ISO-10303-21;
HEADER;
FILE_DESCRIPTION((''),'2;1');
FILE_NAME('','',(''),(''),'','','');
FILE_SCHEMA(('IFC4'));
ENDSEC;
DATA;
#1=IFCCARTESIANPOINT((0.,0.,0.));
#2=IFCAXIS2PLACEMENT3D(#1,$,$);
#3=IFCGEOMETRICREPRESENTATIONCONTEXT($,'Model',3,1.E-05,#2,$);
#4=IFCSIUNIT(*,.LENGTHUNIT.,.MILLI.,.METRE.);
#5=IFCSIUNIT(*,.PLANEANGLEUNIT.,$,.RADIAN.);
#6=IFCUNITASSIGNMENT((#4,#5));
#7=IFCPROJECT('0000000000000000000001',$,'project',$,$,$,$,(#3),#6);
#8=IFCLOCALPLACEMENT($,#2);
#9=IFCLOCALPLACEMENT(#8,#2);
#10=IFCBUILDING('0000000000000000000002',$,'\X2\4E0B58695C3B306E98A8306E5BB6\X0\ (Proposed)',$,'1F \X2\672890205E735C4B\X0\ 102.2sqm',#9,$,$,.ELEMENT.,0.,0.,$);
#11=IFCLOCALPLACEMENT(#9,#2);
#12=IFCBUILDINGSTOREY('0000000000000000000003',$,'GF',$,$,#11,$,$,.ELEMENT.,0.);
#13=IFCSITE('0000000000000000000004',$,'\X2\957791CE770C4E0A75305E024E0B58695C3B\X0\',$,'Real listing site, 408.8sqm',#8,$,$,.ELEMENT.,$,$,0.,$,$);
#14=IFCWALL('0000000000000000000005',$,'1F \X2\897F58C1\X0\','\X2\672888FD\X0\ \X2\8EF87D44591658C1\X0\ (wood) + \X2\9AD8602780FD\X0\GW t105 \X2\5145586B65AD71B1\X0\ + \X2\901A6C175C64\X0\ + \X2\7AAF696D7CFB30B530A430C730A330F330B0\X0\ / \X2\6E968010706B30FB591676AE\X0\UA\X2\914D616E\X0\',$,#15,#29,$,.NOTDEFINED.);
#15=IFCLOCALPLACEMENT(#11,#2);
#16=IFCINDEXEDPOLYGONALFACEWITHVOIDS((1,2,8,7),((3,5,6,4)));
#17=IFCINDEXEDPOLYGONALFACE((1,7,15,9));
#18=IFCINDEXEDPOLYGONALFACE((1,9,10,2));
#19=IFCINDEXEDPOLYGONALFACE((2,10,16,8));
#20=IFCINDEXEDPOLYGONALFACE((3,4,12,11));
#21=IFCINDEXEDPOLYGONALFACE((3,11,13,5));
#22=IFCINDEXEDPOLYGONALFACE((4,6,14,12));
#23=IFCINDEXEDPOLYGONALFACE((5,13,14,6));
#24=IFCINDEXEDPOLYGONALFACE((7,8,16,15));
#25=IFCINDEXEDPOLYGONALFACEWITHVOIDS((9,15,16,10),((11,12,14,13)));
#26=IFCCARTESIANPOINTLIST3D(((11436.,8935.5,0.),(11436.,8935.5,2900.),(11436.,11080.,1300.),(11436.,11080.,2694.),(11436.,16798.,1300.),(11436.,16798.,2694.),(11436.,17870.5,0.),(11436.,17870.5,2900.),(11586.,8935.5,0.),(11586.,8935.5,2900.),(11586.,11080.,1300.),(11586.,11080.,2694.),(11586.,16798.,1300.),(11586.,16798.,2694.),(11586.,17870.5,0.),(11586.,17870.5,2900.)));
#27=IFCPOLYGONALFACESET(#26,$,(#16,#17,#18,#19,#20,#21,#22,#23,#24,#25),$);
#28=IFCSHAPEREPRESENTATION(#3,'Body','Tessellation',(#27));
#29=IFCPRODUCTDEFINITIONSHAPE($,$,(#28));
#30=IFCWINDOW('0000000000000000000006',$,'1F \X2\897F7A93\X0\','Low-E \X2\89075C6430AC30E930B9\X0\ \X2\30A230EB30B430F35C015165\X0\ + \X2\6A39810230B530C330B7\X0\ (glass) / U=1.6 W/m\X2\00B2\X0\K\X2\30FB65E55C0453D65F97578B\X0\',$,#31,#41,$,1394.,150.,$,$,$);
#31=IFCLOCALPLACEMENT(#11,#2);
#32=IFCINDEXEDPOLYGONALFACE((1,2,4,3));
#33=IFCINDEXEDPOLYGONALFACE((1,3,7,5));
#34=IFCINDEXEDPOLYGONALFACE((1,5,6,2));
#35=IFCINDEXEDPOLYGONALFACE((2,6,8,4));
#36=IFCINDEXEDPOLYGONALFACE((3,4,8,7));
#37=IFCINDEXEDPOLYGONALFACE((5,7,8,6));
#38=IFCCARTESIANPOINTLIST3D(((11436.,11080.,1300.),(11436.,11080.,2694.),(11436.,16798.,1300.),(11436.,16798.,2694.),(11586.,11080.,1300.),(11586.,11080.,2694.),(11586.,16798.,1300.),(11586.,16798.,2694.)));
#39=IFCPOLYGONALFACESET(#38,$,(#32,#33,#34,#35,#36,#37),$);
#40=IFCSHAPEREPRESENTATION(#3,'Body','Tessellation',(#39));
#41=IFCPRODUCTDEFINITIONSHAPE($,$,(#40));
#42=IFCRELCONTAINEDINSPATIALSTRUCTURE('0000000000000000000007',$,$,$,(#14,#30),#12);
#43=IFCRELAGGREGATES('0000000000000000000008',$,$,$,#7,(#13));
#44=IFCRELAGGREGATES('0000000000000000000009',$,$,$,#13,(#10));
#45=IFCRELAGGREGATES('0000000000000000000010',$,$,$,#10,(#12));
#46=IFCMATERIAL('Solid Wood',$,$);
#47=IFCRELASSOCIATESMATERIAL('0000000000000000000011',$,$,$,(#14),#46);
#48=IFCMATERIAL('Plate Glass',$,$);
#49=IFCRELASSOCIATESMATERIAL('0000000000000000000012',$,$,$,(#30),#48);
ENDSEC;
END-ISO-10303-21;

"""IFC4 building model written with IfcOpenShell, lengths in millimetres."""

from ifc_helpers import new_model, si_unit, frame, frame_2d, origin, place, context, project, spatial, rectangle, extrude, material, element, fill, save


model = new_model("IFC4")

# Units and contexts
model_context = context("Model", 3, precision=1e-05, world=origin())
ifc_project = project(units=[si_unit("LENGTHUNIT", "METRE", prefix="MILLI"), si_unit("PLANEANGLEUNIT", "RADIAN")], contexts=[model_context])

# Site, building, storey
site_placement = place(None, origin())
site = spatial("IfcSite", under=ifc_project, at=site_placement, Name="長野県上田市下塩尻", ObjectType="Real listing site, 408.8sqm", CompositionType="ELEMENT", RefElevation=0.0)
building_placement = place(site_placement, origin())
building = spatial("IfcBuilding", under=site, at=building_placement, Name="下塩尻の風の家 (Proposed)", ObjectType="1F 木造平屋 102.2sqm", CompositionType="ELEMENT", ElevationOfRefHeight=0.0, ElevationOfTerrain=0.0)
storey_placement = place(building_placement, origin())
storey = spatial("IfcBuildingStorey", under=building, at=storey_placement, Name="GF", CompositionType="ELEMENT", Elevation=0.0)

# Shared definitions
ifc_material_1 = material(Name="Solid Wood")

# Shared definitions
ifc_material_2 = material(Name="Plate Glass")

# Wall, opening, window
wall_1_placement = place(storey_placement, frame((5718.0, 4468.0, 0.0)))
wall_1 = element("IfcWall", 1, at=wall_1_placement, inside=storey, material=ifc_material_1, Name="1F 西壁", Description="木製 軸組外壁 (wood) + 高性能GW t105 充填断熱 + 通気層 + 窯業系サイディング / 準耐火・外皮UA配慮", PredefinedType="NOTDEFINED", context=model_context, shape_type="SweptSolid", body=[
    extrude(rectangle(XDim=150.0, YDim=8935.0, at=frame_2d((75.0, 4467.0))), frame((5718.0, 4468.0, 0.0)), (0.0, 0.0, 1.0), 2900.0),
])
opening_1_placement = place(storey_placement, frame((5718.0, 5540.0, 650.0)))
opening_1 = element("IfcOpeningElement", 2, at=opening_1_placement, cuts=wall_1, PredefinedType="NOTDEFINED", context=model_context, shape_type="SweptSolid", body=[
    extrude(rectangle(XDim=150.0, YDim=5718.0, at=frame_2d((75.0, 2859.0))), frame((5718.0, 5540.0, 650.0)), (0.0, 0.0, 1.0), 1394.0),
])
window_1_placement = place(storey_placement, frame((5718.0, 5540.0, 650.0)))
window_1 = element("IfcWindow", 3, at=window_1_placement, inside=storey, material=ifc_material_2, Name="1F 西窓", Description="Low-E 複層ガラス アルゴン封入 + 樹脂サッシ (glass) / U=1.6 W/m²K・日射取得型", OverallHeight=1394.0, OverallWidth=150.0, context=model_context, shape_type="SweptSolid", body=[
    extrude(rectangle(XDim=150.0, YDim=5718.0, at=frame_2d((75.0, 2859.0))), frame((5718.0, 5540.0, 650.0)), (0.0, 0.0, 1.0), 1394.0),
])
fill(opening_1, window_1)

save(model, "model.ifc")
